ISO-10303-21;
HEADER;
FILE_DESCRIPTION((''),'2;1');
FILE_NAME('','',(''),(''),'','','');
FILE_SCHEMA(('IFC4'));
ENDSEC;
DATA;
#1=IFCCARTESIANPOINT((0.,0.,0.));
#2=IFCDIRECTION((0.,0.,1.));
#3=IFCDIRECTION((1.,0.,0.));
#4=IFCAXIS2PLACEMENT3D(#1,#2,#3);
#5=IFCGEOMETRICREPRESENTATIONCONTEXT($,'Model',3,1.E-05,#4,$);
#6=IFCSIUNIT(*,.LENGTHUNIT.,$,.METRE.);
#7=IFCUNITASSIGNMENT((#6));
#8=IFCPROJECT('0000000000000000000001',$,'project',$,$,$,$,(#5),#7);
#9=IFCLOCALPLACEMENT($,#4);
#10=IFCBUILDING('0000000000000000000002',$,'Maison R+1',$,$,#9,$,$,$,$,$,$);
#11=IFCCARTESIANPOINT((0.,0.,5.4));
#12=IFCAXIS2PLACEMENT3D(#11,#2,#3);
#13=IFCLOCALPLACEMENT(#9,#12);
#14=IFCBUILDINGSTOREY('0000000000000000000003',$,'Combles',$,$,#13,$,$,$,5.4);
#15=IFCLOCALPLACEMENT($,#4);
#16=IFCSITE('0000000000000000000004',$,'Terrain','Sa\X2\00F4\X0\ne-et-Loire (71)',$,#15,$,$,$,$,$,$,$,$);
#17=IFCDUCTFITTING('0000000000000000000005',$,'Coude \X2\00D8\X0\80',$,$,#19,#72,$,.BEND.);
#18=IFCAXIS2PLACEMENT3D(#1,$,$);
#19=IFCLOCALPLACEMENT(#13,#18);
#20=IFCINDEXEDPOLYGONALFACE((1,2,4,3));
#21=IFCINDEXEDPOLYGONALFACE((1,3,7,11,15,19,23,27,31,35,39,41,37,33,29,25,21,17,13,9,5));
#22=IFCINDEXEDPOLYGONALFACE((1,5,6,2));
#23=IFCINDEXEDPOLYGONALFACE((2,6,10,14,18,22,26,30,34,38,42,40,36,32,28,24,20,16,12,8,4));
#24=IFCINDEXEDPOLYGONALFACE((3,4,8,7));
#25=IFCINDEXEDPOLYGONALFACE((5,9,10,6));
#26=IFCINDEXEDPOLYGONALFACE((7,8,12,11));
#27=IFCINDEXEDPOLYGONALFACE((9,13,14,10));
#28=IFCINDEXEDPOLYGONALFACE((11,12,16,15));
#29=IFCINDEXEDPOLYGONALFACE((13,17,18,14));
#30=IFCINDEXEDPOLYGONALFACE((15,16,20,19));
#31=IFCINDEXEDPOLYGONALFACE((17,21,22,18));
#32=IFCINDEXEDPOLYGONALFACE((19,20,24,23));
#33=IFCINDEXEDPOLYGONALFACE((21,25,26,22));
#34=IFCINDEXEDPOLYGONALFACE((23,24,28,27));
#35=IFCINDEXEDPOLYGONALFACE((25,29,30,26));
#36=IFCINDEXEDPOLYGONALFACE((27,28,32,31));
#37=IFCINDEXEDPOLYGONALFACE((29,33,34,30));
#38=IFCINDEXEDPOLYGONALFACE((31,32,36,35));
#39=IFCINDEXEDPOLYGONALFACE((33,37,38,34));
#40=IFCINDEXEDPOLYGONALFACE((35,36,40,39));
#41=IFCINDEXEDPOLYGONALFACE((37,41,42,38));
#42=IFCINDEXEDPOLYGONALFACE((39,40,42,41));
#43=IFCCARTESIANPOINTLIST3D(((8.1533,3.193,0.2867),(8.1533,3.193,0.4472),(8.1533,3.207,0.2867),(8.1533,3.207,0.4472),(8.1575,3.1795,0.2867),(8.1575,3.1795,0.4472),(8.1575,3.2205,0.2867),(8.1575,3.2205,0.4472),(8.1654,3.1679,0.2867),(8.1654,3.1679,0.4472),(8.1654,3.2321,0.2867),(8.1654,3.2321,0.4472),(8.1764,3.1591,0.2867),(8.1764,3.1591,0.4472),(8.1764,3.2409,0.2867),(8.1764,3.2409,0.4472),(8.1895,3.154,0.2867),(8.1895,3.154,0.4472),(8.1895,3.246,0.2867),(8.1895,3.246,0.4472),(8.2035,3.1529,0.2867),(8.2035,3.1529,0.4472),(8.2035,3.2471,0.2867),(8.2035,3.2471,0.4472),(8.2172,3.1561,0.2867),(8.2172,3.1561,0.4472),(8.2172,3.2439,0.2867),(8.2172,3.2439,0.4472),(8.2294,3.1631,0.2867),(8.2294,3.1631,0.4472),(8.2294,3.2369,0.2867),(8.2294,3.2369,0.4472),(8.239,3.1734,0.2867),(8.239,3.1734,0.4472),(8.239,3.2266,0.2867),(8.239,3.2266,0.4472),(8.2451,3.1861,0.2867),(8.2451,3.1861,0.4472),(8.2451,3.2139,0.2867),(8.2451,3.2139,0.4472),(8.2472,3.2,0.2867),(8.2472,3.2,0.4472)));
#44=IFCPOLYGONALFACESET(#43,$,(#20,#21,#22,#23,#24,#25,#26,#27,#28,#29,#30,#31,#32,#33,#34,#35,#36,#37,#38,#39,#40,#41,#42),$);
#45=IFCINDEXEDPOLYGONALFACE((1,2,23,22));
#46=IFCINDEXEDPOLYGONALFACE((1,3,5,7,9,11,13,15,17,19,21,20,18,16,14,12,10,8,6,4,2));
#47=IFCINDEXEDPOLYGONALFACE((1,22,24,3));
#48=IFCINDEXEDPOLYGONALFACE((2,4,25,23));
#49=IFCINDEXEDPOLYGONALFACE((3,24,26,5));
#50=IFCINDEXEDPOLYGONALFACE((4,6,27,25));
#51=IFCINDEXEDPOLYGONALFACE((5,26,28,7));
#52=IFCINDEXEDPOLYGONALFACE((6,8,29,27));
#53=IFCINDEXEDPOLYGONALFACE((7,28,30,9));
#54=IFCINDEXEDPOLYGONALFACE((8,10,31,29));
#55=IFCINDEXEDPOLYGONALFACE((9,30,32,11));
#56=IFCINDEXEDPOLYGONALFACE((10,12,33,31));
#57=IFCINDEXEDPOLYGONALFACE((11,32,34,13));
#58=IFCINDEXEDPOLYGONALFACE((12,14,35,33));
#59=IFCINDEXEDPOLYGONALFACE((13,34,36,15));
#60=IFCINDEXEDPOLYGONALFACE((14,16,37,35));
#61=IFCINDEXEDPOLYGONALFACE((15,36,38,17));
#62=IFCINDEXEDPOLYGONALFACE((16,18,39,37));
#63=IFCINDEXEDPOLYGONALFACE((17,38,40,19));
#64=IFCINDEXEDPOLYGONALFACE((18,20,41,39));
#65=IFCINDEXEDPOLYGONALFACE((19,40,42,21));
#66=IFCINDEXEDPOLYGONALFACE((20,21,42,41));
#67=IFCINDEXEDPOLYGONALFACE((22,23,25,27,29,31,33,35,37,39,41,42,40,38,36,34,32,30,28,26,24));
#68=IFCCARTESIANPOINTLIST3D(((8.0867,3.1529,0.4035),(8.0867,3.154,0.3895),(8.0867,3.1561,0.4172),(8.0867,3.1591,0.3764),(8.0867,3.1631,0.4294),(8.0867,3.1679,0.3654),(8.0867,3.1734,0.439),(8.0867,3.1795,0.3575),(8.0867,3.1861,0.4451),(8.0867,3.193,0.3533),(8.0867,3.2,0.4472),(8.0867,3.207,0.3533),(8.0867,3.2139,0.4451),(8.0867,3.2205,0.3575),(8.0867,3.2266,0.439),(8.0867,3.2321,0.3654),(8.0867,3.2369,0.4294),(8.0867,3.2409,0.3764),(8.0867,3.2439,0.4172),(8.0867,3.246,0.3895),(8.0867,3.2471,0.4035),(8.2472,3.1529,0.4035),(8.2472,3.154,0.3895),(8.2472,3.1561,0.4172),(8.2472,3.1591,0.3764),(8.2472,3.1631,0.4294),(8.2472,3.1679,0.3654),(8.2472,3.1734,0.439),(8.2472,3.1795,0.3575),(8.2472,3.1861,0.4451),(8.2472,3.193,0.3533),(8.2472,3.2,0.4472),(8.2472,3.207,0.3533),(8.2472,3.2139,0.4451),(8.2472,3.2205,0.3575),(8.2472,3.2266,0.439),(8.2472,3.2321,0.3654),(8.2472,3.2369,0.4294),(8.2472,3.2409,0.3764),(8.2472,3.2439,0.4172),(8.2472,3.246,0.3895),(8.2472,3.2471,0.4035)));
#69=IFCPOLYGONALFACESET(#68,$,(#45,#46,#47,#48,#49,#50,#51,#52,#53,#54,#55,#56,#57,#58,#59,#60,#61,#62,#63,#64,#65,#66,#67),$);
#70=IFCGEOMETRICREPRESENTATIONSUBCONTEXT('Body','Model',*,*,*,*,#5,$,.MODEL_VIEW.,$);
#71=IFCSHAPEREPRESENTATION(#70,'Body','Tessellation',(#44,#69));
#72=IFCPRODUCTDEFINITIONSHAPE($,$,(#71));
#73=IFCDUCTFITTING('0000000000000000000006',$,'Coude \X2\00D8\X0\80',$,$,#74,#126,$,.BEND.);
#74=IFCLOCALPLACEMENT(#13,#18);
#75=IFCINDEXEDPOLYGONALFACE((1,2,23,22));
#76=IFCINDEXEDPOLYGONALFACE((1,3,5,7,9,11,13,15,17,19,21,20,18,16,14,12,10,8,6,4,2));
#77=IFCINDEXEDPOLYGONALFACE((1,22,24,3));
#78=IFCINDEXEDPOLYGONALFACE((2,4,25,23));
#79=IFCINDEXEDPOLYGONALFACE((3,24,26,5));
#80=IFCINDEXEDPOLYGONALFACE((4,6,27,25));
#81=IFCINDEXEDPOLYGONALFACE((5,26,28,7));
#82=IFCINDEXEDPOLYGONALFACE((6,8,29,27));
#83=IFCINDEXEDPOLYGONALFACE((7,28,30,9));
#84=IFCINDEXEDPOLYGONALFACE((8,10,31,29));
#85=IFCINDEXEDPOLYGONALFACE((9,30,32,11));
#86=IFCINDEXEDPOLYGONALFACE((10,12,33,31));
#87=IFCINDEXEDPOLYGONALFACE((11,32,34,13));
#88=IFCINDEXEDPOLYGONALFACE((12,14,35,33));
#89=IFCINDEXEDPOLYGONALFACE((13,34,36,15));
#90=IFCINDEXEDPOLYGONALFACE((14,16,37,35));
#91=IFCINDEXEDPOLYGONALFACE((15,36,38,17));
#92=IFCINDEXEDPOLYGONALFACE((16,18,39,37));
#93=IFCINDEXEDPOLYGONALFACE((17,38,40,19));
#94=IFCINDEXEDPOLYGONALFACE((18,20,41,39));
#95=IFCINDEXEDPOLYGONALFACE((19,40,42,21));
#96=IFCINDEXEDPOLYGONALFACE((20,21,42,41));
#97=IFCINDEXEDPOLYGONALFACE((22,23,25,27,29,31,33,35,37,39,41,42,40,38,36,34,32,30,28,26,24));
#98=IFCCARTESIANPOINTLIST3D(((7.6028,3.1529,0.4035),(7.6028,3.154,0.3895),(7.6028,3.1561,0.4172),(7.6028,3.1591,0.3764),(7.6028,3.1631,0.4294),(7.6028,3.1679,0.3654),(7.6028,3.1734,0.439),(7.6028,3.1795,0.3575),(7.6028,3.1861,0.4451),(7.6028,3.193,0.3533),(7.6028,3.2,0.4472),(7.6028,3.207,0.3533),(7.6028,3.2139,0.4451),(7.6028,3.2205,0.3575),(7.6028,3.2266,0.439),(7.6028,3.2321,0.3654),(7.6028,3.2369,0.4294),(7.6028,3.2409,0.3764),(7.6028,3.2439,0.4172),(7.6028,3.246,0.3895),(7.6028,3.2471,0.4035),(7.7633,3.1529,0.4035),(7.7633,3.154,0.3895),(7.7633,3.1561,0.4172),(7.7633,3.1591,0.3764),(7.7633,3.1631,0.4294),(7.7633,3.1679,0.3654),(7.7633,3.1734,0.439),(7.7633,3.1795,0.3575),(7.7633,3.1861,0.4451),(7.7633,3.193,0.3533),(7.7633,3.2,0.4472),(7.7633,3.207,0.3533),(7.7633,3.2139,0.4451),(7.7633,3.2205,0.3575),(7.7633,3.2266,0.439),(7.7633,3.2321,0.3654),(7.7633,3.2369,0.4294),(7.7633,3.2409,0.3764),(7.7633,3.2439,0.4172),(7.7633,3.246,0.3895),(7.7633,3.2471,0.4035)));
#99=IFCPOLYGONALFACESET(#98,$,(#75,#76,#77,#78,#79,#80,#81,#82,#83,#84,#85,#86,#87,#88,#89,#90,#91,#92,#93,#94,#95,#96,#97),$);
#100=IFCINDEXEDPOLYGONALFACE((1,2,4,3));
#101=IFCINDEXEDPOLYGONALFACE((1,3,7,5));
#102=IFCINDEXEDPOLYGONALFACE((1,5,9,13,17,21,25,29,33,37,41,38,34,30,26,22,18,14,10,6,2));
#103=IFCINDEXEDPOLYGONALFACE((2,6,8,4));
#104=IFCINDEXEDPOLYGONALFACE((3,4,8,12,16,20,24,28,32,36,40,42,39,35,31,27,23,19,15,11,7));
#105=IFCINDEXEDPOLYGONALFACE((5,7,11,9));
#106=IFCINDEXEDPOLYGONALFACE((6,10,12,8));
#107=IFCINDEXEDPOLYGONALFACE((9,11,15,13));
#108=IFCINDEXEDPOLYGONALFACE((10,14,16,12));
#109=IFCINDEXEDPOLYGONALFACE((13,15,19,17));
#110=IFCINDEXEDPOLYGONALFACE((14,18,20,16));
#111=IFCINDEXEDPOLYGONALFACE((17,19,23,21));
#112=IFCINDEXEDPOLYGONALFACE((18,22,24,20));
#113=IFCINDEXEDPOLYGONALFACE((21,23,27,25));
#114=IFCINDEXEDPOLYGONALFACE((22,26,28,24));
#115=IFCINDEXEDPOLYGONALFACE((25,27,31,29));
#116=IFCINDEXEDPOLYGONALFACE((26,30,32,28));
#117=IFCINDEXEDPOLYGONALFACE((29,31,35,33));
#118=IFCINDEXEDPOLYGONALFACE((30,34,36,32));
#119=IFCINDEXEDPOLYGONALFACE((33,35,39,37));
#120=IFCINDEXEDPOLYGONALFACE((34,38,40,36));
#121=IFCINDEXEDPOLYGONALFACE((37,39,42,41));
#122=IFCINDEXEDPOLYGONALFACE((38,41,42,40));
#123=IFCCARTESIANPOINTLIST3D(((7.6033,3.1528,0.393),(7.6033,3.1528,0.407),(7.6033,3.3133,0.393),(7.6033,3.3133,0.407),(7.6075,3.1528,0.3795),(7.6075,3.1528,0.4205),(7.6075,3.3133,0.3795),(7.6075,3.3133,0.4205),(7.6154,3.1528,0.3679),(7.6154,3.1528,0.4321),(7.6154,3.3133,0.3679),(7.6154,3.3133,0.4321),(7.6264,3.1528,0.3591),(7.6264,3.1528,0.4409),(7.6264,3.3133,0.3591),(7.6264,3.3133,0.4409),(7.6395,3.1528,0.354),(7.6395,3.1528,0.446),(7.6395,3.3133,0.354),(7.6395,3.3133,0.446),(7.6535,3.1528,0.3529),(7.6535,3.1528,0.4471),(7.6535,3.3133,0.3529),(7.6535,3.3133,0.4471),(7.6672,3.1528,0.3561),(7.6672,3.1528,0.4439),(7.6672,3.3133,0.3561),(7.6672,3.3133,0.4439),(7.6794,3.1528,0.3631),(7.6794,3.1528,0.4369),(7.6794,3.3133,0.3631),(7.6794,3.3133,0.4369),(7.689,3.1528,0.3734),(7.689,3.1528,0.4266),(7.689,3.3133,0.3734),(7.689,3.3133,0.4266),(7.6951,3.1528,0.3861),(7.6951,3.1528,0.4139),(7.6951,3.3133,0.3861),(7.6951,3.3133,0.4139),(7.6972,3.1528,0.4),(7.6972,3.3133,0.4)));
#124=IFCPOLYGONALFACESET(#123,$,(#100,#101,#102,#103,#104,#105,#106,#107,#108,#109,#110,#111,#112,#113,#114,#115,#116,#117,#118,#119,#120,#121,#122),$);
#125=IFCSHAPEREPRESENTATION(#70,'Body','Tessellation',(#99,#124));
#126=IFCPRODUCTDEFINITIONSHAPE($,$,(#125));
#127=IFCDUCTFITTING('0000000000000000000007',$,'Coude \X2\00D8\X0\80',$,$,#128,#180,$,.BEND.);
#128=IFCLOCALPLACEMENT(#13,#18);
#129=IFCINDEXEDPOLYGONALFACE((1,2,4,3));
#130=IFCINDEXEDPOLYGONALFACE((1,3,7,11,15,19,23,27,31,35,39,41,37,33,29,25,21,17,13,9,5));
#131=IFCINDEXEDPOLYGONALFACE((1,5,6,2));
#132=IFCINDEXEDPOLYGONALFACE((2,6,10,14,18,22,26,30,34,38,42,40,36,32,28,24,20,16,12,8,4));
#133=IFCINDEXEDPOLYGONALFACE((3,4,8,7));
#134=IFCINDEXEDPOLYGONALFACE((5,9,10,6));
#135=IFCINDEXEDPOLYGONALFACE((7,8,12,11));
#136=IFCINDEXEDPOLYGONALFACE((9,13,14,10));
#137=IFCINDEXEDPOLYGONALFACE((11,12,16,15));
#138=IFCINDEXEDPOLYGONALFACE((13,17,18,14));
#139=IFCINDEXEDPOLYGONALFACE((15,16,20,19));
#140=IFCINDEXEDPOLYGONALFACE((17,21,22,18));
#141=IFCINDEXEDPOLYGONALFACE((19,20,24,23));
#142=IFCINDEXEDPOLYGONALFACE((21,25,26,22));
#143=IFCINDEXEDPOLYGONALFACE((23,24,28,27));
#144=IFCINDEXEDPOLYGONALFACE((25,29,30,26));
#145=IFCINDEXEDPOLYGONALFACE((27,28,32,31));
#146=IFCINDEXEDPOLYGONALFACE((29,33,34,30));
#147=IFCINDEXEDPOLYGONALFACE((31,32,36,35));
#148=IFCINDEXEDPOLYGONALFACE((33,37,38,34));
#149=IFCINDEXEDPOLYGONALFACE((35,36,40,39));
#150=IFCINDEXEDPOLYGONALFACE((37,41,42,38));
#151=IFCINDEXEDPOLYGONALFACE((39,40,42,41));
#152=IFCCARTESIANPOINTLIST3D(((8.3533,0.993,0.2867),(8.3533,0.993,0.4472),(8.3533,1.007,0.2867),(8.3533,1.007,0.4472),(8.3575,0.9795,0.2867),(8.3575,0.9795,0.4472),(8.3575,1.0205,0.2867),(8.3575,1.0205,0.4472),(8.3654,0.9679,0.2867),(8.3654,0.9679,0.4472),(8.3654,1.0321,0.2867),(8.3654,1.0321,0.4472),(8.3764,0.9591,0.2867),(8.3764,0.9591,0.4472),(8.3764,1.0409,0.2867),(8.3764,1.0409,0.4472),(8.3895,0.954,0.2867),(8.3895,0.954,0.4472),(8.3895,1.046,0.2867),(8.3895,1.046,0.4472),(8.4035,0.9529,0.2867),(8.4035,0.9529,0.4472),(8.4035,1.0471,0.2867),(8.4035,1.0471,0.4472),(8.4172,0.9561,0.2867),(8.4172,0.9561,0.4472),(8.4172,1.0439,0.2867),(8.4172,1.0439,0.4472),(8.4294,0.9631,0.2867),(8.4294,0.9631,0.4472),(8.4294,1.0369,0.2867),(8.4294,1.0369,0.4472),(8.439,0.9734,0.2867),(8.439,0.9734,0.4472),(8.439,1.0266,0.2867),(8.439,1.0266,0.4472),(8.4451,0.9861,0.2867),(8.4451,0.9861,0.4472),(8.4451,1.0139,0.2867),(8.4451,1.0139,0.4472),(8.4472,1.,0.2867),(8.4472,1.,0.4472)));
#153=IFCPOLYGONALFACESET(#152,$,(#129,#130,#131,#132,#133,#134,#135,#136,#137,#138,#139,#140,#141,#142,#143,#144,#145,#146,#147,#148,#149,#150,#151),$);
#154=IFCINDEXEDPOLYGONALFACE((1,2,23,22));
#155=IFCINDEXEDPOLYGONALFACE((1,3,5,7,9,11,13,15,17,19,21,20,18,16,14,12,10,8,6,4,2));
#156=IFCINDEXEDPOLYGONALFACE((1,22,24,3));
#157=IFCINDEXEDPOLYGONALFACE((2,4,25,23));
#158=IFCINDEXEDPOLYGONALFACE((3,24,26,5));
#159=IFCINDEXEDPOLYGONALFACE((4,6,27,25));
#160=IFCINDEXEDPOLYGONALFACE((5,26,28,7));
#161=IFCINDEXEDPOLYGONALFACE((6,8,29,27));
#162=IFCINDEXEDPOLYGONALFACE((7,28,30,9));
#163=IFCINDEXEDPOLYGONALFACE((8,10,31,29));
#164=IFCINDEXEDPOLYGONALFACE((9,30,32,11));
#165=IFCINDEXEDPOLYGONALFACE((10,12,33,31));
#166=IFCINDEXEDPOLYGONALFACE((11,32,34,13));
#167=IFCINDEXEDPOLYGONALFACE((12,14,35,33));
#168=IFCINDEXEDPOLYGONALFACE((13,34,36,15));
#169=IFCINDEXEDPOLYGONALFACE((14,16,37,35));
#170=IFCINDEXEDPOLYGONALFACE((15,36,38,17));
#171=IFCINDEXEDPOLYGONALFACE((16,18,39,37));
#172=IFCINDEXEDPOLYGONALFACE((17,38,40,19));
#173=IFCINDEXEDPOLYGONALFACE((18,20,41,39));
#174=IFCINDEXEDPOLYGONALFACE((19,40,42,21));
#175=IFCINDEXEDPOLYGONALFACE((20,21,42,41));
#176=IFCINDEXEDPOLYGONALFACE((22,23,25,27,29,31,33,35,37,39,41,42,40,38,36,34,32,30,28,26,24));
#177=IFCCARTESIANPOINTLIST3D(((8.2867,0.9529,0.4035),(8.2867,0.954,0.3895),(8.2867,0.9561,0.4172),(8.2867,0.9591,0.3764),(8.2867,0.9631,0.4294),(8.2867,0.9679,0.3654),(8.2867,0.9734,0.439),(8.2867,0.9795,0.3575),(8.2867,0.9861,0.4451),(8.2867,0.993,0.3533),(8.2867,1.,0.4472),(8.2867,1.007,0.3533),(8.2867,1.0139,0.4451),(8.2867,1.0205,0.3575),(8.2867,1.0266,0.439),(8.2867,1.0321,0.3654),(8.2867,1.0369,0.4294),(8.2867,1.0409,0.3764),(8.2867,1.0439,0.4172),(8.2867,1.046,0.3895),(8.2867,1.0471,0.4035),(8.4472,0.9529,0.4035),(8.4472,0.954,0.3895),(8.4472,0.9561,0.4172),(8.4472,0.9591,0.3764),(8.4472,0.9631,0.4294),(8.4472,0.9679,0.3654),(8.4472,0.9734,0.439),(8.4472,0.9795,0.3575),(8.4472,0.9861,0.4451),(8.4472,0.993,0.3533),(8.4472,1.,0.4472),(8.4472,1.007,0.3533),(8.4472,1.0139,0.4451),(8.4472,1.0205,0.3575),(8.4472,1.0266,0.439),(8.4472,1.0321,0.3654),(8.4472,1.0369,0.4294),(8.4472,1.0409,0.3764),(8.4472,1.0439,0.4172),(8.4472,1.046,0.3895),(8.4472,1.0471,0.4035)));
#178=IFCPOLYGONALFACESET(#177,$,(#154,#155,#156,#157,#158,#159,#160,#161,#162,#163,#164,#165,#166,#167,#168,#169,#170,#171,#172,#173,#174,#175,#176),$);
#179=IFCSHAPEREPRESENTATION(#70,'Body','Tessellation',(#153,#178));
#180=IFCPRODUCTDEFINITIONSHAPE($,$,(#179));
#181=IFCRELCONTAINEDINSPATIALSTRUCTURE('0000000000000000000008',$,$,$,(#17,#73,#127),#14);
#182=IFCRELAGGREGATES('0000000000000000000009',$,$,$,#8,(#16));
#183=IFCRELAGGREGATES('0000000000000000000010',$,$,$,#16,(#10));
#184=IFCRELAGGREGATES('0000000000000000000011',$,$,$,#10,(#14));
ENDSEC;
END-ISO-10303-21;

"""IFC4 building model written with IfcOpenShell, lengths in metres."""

from ifc_helpers import new_model, si_unit, frame, origin_with_axes, place, context, subcontext, project, spatial, circle, extrude, element, save


model = new_model("IFC4")

# Units and contexts
model_context = context("Model", 3, precision=1e-05, world=origin_with_axes())
body_context = subcontext(model_context, "Body", "Model", "MODEL_VIEW")
ifc_project = project(units=[si_unit("LENGTHUNIT", "METRE")], contexts=[model_context])

# Site, building, storey
site_placement = place(None, origin_with_axes())
site = spatial("IfcSite", under=ifc_project, at=site_placement, Name="Terrain", Description="Saône-et-Loire (71)")
building_placement = place(None, origin_with_axes())
building = spatial("IfcBuilding", under=site, at=building_placement, Name="Maison R+1")
storey_placement = place(building_placement, frame((0.0, 0.0, 5.4), z_axis=(0.0, 0.0, 1.0), x_axis=(1.0, 0.0, 0.0)))
storey = spatial("IfcBuildingStorey", under=building, at=storey_placement, Name="Combles", Elevation=5.4)

# Duct fittings
duct_fitting_1_placement = place(storey_placement, frame((8.2, 3.2, 0.4), z_axis=(0.0, 0.0, 1.0), x_axis=(1.0, 0.0, 0.0)))
element("IfcDuctFitting", 1, at=duct_fitting_1_placement, inside=storey, Name="Coude Ø80", PredefinedType="BEND", context=body_context, shape_type="SweptSolid", body=[
    extrude(circle(Radius=0.0472), frame((0.0, 0.0, 0.0472), z_axis=(0.0, 0.0, -1.0), x_axis=(1.0, 0.0, 0.0)), (0.0, 0.0, 1.0), 0.1605),
    extrude(circle(Radius=0.0472), frame((0.0472, 0.0, 0.0), z_axis=(-1.0, 0.0, 0.0), x_axis=(0.0, 0.0, 1.0)), (0.0, 0.0, 1.0), 0.1605),
])
duct_fitting_2_placement = place(storey_placement, frame((7.65, 3.2, 0.4), z_axis=(0.0, 0.0, 1.0), x_axis=(1.0, 0.0, 0.0)))
element("IfcDuctFitting", 2, at=duct_fitting_2_placement, inside=storey, Name="Coude Ø80", PredefinedType="BEND", context=body_context, shape_type="SweptSolid", body=[
    extrude(circle(Radius=0.0472), frame((-0.0472, 0.0, 0.0), z_axis=(1.0, 0.0, 0.0), x_axis=(0.0, 0.0, 1.0)), (0.0, 0.0, 1.0), 0.1605),
    extrude(circle(Radius=0.0472), frame((0.0, -0.0472, 0.0), z_axis=(0.0, 1.0, 0.0), x_axis=(1.0, 0.0, 0.0)), (0.0, 0.0, 1.0), 0.1605),
])
duct_fitting_3_placement = place(storey_placement, frame((8.4, 1.0, 0.4), z_axis=(0.0, 0.0, 1.0), x_axis=(1.0, 0.0, 0.0)))
element("IfcDuctFitting", 3, at=duct_fitting_3_placement, inside=storey, Name="Coude Ø80", PredefinedType="BEND", context=body_context, shape_type="SweptSolid", body=[
    extrude(circle(Radius=0.0472), frame((0.0, 0.0, 0.0472), z_axis=(0.0, 0.0, -1.0), x_axis=(1.0, 0.0, 0.0)), (0.0, 0.0, 1.0), 0.1605),
    extrude(circle(Radius=0.0472), frame((0.0472, 0.0, 0.0), z_axis=(-1.0, 0.0, 0.0), x_axis=(0.0, 0.0, 1.0)), (0.0, 0.0, 1.0), 0.1605),
])

save(model, "model.ifc")
